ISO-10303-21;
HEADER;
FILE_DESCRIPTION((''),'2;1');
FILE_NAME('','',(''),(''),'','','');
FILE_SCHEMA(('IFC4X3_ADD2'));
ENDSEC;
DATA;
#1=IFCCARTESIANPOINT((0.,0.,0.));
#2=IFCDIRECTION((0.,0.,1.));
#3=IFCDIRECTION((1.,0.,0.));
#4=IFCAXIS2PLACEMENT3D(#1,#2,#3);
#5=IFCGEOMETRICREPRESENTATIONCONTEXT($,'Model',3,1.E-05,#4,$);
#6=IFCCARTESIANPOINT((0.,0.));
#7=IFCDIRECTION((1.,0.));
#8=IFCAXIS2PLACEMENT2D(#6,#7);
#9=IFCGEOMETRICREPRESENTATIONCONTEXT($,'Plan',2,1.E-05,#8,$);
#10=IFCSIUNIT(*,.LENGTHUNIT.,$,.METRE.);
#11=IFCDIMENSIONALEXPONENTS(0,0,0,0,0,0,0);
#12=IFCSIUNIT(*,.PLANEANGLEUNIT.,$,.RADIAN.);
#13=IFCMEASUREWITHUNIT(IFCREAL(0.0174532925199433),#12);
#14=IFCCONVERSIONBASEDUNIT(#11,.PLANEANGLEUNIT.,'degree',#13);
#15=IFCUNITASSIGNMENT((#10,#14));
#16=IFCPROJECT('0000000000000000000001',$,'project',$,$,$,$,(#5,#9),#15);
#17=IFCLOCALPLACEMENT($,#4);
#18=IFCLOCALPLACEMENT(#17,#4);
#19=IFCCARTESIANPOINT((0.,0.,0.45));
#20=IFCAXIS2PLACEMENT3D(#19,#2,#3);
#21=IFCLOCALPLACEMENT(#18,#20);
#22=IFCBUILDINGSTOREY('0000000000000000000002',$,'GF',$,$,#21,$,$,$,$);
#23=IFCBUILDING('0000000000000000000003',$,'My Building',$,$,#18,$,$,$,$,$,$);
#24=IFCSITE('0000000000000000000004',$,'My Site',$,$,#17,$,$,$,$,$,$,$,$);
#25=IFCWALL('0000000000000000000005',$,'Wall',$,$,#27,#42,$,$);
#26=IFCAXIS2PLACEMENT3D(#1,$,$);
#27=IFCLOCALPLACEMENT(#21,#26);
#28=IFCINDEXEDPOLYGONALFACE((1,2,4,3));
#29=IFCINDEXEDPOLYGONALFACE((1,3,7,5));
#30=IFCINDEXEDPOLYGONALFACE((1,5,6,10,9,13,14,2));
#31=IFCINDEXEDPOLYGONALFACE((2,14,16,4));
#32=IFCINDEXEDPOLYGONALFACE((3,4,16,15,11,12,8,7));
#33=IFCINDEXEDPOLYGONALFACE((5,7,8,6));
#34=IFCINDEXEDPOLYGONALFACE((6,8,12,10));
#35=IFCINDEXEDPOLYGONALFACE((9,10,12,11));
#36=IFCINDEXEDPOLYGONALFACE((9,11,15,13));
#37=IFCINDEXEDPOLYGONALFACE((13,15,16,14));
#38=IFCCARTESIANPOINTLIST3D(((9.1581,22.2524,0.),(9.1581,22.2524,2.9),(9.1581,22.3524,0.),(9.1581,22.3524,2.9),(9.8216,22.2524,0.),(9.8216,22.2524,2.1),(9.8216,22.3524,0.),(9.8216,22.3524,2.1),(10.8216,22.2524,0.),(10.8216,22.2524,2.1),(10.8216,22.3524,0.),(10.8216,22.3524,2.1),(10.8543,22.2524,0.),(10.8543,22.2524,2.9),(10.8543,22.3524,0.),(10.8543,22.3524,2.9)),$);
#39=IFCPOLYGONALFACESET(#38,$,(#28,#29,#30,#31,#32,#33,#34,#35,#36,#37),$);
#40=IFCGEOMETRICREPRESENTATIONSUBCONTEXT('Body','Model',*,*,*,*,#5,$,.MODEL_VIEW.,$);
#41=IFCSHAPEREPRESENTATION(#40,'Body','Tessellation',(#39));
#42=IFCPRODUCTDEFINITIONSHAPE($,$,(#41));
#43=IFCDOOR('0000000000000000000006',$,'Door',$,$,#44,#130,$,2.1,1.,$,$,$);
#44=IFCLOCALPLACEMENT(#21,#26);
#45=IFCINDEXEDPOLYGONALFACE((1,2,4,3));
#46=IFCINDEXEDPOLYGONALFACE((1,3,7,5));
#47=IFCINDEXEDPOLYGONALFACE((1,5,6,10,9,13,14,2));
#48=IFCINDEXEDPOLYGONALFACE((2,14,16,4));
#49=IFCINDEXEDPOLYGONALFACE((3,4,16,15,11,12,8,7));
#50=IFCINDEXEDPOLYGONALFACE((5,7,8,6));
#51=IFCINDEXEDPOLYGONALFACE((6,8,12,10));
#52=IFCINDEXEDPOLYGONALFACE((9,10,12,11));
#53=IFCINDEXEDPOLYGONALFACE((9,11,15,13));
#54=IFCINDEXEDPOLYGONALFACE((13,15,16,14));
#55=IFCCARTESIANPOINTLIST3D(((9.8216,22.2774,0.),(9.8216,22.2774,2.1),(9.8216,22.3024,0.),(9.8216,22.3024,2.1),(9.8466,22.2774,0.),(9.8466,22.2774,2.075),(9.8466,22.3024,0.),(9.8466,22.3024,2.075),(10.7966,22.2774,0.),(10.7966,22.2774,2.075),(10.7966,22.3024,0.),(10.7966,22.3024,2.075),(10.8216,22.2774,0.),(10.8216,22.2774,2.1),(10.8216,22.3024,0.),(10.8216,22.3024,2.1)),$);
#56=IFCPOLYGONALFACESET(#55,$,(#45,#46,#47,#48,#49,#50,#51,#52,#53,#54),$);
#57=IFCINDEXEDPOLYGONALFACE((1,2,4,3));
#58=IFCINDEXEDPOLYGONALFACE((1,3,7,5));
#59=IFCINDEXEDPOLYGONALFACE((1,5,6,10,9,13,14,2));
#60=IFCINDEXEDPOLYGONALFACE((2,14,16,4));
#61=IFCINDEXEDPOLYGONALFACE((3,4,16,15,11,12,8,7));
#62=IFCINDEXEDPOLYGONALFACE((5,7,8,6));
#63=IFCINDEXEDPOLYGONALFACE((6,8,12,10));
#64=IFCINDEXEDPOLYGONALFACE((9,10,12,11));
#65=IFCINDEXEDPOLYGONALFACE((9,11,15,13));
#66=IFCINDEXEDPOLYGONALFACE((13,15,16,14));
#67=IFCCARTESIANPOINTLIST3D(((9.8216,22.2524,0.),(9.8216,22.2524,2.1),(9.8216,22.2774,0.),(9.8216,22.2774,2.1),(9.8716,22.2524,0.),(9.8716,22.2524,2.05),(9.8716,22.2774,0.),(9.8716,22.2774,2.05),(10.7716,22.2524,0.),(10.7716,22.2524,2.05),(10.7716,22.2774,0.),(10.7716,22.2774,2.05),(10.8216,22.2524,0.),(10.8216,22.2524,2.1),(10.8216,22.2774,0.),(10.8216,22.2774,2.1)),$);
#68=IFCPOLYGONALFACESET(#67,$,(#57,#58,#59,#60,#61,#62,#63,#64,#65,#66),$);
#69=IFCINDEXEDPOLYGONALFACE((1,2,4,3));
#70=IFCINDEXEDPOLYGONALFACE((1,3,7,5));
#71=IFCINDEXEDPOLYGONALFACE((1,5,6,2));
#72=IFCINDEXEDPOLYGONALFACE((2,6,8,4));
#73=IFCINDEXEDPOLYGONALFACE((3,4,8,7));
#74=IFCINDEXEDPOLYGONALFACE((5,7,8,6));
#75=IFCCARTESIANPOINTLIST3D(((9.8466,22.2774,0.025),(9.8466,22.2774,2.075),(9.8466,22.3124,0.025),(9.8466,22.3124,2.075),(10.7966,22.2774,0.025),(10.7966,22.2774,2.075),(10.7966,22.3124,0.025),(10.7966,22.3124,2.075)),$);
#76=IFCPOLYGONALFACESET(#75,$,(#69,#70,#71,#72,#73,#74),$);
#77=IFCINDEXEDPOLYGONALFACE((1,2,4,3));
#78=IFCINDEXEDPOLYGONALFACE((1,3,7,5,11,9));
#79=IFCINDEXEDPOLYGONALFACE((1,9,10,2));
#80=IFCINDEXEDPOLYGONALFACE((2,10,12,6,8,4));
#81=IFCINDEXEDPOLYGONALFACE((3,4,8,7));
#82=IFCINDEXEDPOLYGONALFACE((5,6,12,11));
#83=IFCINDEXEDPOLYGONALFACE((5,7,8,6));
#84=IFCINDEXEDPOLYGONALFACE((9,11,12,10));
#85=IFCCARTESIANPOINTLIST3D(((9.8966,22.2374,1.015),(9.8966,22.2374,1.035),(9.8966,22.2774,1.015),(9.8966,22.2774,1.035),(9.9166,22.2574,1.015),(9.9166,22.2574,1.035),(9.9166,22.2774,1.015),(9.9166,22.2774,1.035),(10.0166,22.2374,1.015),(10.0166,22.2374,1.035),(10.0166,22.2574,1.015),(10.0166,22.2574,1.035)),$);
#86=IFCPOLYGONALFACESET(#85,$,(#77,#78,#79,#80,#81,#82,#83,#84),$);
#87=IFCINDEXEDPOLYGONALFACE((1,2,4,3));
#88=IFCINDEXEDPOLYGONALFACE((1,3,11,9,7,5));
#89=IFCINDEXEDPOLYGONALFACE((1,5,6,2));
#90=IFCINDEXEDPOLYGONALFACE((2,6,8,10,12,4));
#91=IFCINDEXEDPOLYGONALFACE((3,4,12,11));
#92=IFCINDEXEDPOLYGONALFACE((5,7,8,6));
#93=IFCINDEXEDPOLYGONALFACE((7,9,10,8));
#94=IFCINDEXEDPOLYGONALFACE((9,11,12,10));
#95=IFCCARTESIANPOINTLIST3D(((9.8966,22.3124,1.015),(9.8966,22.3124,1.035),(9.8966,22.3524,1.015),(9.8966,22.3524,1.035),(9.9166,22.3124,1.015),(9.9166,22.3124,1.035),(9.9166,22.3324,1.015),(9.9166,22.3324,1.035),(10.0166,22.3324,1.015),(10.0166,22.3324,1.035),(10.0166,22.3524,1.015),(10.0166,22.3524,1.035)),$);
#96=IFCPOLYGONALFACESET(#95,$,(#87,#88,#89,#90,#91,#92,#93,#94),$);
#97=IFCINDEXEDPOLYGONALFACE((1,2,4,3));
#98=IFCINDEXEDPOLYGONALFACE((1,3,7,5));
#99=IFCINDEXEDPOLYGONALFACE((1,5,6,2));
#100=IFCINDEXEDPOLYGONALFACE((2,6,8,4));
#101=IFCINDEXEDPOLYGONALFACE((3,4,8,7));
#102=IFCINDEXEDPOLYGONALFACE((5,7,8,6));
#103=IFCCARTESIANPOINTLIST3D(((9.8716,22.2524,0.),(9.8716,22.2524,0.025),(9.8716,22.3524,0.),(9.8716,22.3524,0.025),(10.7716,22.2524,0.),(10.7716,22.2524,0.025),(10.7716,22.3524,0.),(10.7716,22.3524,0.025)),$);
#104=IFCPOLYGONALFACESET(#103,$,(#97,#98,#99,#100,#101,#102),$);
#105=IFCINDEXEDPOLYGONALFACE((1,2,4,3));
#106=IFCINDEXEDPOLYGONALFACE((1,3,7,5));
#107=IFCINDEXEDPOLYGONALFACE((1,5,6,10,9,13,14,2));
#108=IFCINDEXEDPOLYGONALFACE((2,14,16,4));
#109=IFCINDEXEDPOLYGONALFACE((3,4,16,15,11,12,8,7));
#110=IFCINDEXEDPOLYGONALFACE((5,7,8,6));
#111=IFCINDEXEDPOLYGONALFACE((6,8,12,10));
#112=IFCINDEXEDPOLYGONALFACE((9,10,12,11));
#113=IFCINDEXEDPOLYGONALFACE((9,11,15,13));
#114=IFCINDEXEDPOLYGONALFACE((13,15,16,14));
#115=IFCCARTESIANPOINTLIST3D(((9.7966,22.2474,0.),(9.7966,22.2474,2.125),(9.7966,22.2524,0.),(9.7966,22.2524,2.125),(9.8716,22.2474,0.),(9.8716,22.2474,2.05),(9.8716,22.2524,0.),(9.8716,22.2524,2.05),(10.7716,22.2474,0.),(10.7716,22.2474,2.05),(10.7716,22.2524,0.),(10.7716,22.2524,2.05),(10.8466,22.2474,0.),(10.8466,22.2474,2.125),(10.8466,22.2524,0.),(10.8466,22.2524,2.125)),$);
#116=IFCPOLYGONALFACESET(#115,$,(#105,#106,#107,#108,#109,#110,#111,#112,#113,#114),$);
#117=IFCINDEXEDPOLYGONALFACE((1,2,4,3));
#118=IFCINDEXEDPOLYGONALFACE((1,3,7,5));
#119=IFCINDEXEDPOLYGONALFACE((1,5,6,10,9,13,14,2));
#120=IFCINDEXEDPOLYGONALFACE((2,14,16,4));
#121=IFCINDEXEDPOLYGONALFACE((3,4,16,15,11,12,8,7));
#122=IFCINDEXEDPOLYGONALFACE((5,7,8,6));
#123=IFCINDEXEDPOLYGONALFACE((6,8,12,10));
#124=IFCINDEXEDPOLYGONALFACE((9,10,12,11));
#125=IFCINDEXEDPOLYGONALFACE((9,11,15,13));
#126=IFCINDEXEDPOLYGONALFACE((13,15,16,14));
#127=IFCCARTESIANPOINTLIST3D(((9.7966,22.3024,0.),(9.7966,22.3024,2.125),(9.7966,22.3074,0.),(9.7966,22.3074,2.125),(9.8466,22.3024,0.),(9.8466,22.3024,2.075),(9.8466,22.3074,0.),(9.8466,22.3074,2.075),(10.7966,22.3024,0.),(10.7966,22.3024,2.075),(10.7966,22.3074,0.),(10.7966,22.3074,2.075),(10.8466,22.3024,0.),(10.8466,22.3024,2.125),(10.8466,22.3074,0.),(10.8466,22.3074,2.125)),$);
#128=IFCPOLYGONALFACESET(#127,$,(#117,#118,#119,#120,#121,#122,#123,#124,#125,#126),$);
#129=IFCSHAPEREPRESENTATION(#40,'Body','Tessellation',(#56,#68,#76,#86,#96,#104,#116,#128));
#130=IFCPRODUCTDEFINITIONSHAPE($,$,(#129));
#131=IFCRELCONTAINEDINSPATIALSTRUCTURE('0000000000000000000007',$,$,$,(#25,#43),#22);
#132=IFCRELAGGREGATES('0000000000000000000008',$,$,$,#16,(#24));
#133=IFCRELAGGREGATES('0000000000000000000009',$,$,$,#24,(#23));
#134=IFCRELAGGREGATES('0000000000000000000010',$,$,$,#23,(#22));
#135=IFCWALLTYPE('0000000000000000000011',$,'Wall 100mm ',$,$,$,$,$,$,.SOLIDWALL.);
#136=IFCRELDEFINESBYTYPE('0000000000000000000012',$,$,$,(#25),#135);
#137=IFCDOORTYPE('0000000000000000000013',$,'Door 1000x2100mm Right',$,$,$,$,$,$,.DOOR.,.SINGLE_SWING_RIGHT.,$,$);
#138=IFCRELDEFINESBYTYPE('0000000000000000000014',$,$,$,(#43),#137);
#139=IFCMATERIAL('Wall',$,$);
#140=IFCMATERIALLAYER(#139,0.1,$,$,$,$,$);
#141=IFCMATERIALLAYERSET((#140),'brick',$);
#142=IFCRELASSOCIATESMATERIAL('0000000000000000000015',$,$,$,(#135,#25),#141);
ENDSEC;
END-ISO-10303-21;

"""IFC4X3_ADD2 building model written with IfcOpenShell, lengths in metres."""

from ifc_helpers import new_model, entity, si_unit, converted_unit, frame, origin_with_axes, origin_2d_with_axis, place, context, subcontext, project, spatial, line, indexed_curve, outline, extrude, shape, source, transform, mapped, material, layer, layer_set, layer_usage, type_object, type_shapes, element, fill, save


model = new_model("IFC4X3_ADD2")

# Units and contexts
model_context = context("Model", 3, precision=1e-05, world=origin_with_axes())
plan_context = context("Plan", 2, precision=1e-05, world=origin_2d_with_axis())
body_context_1 = subcontext(model_context, "Body", "Model", "MODEL_VIEW")
body_context_2 = subcontext(plan_context, "Body", "Plan", "PLAN_VIEW")
ifc_project = project(units=[si_unit("LENGTHUNIT", "METRE"), converted_unit("PLANEANGLEUNIT", "degree", entity("IfcReal", 0.0174532925199433), si_unit("PLANEANGLEUNIT", "RADIAN"), dimensions=[0, 0, 0, 0, 0, 0, 0])], contexts=[model_context, plan_context])

# Site, building, storey
site_placement = place(None, origin_with_axes())
site = spatial("IfcSite", under=ifc_project, at=site_placement, Name="My Site")
building_placement = place(site_placement, origin_with_axes())
building = spatial("IfcBuilding", under=site, at=building_placement, Name="My Building")
storey_placement = place(building_placement, frame((0.0, 0.0, 0.45), z_axis=(0.0, 0.0, 1.0), x_axis=(1.0, 0.0, 0.0)))
storey = spatial("IfcBuildingStorey", under=building, at=storey_placement, Name="GF")

# Shared definitions
ifc_material_1 = material(Name="Wall")

# Shared definitions
ifc_layer_1 = layer(ifc_material_1, 0.1)
ifc_layer_set_1 = layer_set([ifc_layer_1], Name="brick")
wall_type_1 = type_object("IfcWallType", Name="Wall 100mm ", PredefinedType="SOLIDWALL", material=ifc_layer_set_1)

# Wall, opening, door
ifc_layer_usage_1 = layer_usage(ifc_layer_set_1, "AXIS2", "POSITIVE", 0.0)
wall_1_placement = place(storey_placement, frame((9.1581, 22.2524, 0.0), z_axis=(0.0, 0.0, 1.0), x_axis=(1.0, 0.0, 0.0)))
wall_1 = element("IfcWall", 1, at=wall_1_placement, inside=storey, type_object=wall_type_1, material=ifc_layer_usage_1, Name="Wall", context=body_context_1, shape_type="SweptSolid", body=[
    extrude(outline(indexed_curve([(0.0, 0.0), (0.0, 0.1), (1.6962, 0.1), (1.6962, 0.0), (0.0, 0.0)], self_intersect=False)), origin_with_axes(), (0.0, 0.0, 1.0), 2.9),
])
shared_shape_1 = source(origin_with_axes(), body_context_1, "Body", "SweptSolid", [
    extrude(outline(indexed_curve([(0.0, 0.0), (1.0, 0.0), (1.0, 2.1), (0.0, 2.1)], segments=[line(1, 2, 3, 4, 1)])), frame((0.0, -0.6, 0.0), z_axis=(0.0, -1.0, 0.0), x_axis=(1.0, 0.0, 0.0)), (0.0, 0.0, -1.0), 1.2),
])
opening_1_placement = place(wall_1_placement, frame((0.6635, 0.0, 0.0), z_axis=(0.0, 0.0, 1.0), x_axis=(1.0, 0.0, 0.0)))
opening_1 = element("IfcOpeningElement", 2, at=opening_1_placement, cuts=wall_1, PredefinedType="OPENING", context=body_context_1, shape_type="MappedRepresentation", body=[
    mapped(shared_shape_1, transform((0.0, 0.0, 0.0), x_axis=(1.0, 0.0, 0.0), y_axis=(0.0, 1.0, 0.0), z_axis=(0.0, 0.0, 1.0), scale=1.0)),
])
door_type_1 = type_object("IfcDoorType", Name="Door 1000x2100mm Right", OperationType="SINGLE_SWING_RIGHT", PredefinedType="DOOR")
shared_shape_2 = source(origin_with_axes(), body_context_1, "Body", "SweptSolid", [
    extrude(outline(indexed_curve([(0.0, 0.0), (0.0, 2.1), (1.0, 2.1), (1.0, 0.0), (0.975, 0.0), (0.975, 2.075), (0.025, 2.075), (0.025, 0.0)], segments=[line(1, 2, 3, 4, 5, 6, 7, 8, 1)])), frame((0.0, 0.025, 0.0), z_axis=(0.0, -1.0, 0.0), x_axis=(1.0, 0.0, 0.0)), (0.0, 0.0, -1.0), 0.025),
    extrude(outline(indexed_curve([(0.0, 0.0), (0.0, 2.1), (1.0, 2.1), (1.0, 0.0), (0.95, 0.0), (0.95, 2.05), (0.05, 2.05), (0.05, 0.0)], segments=[line(1, 2, 3, 4, 5, 6, 7, 8, 1)])), frame((0.0, 0.0, 0.0), z_axis=(0.0, -1.0, 0.0), x_axis=(1.0, 0.0, 0.0)), (0.0, 0.0, -1.0), 0.025),
    extrude(outline(indexed_curve([(0.0, 0.0), (0.95, 0.0), (0.95, 0.035), (0.0, 0.035)], segments=[line(1, 2, 3, 4, 1)])), frame((0.025, 0.025, 0.025), z_axis=(0.0, 0.0, 1.0), x_axis=(1.0, 0.0, 0.0)), (0.0, 0.0, 1.0), 2.05),
    extrude(outline(indexed_curve([(0.0, 0.0), (0.0, -0.04), (0.12, -0.04), (0.12, -0.02), (0.02, -0.02), (0.02, 0.0)], segments=[line(1, 2, 3, 4, 5, 6, 1)])), frame((0.075, 0.025, 1.015), z_axis=(0.0, 0.0, 1.0), x_axis=(1.0, 0.0, 0.0)), (0.0, 0.0, 1.0), 0.02),
    extrude(outline(indexed_curve([(0.0, 0.0), (0.0, 0.04), (0.12, 0.04), (0.12, 0.02), (0.02, 0.02), (0.02, 0.0)], segments=[line(1, 2, 3, 4, 5, 6, 1)])), frame((0.075, 0.06, 1.015), z_axis=(0.0, 0.0, 1.0), x_axis=(1.0, 0.0, 0.0)), (0.0, 0.0, 1.0), 0.02),
    extrude(outline(indexed_curve([(0.0, 0.0), (0.9, 0.0), (0.9, 0.1), (0.0, 0.1)], segments=[line(1, 2, 3, 4, 1)])), frame((0.05, 0.0, 0.0), z_axis=(0.0, 0.0, 1.0), x_axis=(1.0, 0.0, 0.0)), (0.0, 0.0, 1.0), 0.025),
    extrude(outline(indexed_curve([(0.0, 0.0), (0.0, 2.125), (1.05, 2.125), (1.05, 0.0), (0.975, 0.0), (0.975, 2.05), (0.075, 2.05), (0.075, 0.0)], segments=[line(1, 2, 3, 4, 5, 6, 7, 8, 1)])), frame((-0.025, -0.005, 0.0), z_axis=(0.0, -1.0, 0.0), x_axis=(1.0, 0.0, 0.0)), (0.0, 0.0, -1.0), 0.005),
    extrude(outline(indexed_curve([(0.0, 0.0), (0.0, 2.125), (1.05, 2.125), (1.05, 0.0), (1.0, 0.0), (1.0, 2.075), (0.05, 2.075), (0.05, 0.0)], segments=[line(1, 2, 3, 4, 5, 6, 7, 8, 1)])), frame((-0.025, 0.05, 0.0), z_axis=(0.0, -1.0, 0.0), x_axis=(1.0, 0.0, 0.0)), (0.0, 0.0, -1.0), 0.005),
])
shared_shape_3 = source(origin_with_axes(), body_context_2, "Body", "Curve2D", [
    entity("IfcIndexedPolyCurve", entity("IfcCartesianPointList2D", [[0.0, 0.0], [0.0, 0.05], [0.025, 0.05], [0.025, 0.025], [0.05, 0.025], [0.05, 0.0]]), [entity("IfcLineIndex", [1, 2, 3, 4, 5, 6, 1])]),
    entity("IfcIndexedPolyCurve", entity("IfcCartesianPointList2D", [[1.0, 0.0], [1.0, 0.05], [0.975, 0.05], [0.975, 0.025], [0.95, 0.025], [0.95, 0.0]]), [entity("IfcLineIndex", [1, 2, 3, 4, 5, 6, 1])]),
    entity("IfcTrimmedCurve", entity("IfcEllipse", entity("IfcAxis2Placement2D", entity("IfcCartesianPoint", [0.94, 0.05]), entity("IfcDirection", [1.0, 0.0])), 0.915, 0.95), [entity("IfcCartesianPoint", [0.94, 1.0])], [entity("IfcCartesianPoint", [0.025, 0.05])], True, "CARTESIAN"),
    entity("IfcIndexedPolyCurve", entity("IfcCartesianPointList2D", [[0.975, 0.05], [0.94, 0.05], [0.94, 1.0], [0.975, 1.0]]), [entity("IfcLineIndex", [1, 2, 3, 4, 1])]),
])
type_shapes(door_type_1, [shared_shape_2, shared_shape_3])
door_1_placement = place(opening_1_placement, origin_with_axes())
door_1 = element("IfcDoor", 3, at=door_1_placement, inside=storey, type_object=door_type_1, Name="Door", OverallHeight=2.1, OverallWidth=1.0, shapes=[
    shape(body_context_1, "Body", "MappedRepresentation", [mapped(shared_shape_2, transform((0.0, 0.0, 0.0), x_axis=(1.0, 0.0, 0.0), y_axis=(0.0, 1.0, 0.0), z_axis=(0.0, 0.0, 1.0), scale=1.0))]),
    shape(body_context_2, "Body", "MappedRepresentation", [mapped(shared_shape_3, transform((0.0, 0.0, 0.0), x_axis=(1.0, 0.0, 0.0), y_axis=(0.0, 1.0, 0.0), z_axis=(0.0, 0.0, 1.0), scale=1.0))]),
])
fill(opening_1, door_1)

save(model, "model.ifc")
